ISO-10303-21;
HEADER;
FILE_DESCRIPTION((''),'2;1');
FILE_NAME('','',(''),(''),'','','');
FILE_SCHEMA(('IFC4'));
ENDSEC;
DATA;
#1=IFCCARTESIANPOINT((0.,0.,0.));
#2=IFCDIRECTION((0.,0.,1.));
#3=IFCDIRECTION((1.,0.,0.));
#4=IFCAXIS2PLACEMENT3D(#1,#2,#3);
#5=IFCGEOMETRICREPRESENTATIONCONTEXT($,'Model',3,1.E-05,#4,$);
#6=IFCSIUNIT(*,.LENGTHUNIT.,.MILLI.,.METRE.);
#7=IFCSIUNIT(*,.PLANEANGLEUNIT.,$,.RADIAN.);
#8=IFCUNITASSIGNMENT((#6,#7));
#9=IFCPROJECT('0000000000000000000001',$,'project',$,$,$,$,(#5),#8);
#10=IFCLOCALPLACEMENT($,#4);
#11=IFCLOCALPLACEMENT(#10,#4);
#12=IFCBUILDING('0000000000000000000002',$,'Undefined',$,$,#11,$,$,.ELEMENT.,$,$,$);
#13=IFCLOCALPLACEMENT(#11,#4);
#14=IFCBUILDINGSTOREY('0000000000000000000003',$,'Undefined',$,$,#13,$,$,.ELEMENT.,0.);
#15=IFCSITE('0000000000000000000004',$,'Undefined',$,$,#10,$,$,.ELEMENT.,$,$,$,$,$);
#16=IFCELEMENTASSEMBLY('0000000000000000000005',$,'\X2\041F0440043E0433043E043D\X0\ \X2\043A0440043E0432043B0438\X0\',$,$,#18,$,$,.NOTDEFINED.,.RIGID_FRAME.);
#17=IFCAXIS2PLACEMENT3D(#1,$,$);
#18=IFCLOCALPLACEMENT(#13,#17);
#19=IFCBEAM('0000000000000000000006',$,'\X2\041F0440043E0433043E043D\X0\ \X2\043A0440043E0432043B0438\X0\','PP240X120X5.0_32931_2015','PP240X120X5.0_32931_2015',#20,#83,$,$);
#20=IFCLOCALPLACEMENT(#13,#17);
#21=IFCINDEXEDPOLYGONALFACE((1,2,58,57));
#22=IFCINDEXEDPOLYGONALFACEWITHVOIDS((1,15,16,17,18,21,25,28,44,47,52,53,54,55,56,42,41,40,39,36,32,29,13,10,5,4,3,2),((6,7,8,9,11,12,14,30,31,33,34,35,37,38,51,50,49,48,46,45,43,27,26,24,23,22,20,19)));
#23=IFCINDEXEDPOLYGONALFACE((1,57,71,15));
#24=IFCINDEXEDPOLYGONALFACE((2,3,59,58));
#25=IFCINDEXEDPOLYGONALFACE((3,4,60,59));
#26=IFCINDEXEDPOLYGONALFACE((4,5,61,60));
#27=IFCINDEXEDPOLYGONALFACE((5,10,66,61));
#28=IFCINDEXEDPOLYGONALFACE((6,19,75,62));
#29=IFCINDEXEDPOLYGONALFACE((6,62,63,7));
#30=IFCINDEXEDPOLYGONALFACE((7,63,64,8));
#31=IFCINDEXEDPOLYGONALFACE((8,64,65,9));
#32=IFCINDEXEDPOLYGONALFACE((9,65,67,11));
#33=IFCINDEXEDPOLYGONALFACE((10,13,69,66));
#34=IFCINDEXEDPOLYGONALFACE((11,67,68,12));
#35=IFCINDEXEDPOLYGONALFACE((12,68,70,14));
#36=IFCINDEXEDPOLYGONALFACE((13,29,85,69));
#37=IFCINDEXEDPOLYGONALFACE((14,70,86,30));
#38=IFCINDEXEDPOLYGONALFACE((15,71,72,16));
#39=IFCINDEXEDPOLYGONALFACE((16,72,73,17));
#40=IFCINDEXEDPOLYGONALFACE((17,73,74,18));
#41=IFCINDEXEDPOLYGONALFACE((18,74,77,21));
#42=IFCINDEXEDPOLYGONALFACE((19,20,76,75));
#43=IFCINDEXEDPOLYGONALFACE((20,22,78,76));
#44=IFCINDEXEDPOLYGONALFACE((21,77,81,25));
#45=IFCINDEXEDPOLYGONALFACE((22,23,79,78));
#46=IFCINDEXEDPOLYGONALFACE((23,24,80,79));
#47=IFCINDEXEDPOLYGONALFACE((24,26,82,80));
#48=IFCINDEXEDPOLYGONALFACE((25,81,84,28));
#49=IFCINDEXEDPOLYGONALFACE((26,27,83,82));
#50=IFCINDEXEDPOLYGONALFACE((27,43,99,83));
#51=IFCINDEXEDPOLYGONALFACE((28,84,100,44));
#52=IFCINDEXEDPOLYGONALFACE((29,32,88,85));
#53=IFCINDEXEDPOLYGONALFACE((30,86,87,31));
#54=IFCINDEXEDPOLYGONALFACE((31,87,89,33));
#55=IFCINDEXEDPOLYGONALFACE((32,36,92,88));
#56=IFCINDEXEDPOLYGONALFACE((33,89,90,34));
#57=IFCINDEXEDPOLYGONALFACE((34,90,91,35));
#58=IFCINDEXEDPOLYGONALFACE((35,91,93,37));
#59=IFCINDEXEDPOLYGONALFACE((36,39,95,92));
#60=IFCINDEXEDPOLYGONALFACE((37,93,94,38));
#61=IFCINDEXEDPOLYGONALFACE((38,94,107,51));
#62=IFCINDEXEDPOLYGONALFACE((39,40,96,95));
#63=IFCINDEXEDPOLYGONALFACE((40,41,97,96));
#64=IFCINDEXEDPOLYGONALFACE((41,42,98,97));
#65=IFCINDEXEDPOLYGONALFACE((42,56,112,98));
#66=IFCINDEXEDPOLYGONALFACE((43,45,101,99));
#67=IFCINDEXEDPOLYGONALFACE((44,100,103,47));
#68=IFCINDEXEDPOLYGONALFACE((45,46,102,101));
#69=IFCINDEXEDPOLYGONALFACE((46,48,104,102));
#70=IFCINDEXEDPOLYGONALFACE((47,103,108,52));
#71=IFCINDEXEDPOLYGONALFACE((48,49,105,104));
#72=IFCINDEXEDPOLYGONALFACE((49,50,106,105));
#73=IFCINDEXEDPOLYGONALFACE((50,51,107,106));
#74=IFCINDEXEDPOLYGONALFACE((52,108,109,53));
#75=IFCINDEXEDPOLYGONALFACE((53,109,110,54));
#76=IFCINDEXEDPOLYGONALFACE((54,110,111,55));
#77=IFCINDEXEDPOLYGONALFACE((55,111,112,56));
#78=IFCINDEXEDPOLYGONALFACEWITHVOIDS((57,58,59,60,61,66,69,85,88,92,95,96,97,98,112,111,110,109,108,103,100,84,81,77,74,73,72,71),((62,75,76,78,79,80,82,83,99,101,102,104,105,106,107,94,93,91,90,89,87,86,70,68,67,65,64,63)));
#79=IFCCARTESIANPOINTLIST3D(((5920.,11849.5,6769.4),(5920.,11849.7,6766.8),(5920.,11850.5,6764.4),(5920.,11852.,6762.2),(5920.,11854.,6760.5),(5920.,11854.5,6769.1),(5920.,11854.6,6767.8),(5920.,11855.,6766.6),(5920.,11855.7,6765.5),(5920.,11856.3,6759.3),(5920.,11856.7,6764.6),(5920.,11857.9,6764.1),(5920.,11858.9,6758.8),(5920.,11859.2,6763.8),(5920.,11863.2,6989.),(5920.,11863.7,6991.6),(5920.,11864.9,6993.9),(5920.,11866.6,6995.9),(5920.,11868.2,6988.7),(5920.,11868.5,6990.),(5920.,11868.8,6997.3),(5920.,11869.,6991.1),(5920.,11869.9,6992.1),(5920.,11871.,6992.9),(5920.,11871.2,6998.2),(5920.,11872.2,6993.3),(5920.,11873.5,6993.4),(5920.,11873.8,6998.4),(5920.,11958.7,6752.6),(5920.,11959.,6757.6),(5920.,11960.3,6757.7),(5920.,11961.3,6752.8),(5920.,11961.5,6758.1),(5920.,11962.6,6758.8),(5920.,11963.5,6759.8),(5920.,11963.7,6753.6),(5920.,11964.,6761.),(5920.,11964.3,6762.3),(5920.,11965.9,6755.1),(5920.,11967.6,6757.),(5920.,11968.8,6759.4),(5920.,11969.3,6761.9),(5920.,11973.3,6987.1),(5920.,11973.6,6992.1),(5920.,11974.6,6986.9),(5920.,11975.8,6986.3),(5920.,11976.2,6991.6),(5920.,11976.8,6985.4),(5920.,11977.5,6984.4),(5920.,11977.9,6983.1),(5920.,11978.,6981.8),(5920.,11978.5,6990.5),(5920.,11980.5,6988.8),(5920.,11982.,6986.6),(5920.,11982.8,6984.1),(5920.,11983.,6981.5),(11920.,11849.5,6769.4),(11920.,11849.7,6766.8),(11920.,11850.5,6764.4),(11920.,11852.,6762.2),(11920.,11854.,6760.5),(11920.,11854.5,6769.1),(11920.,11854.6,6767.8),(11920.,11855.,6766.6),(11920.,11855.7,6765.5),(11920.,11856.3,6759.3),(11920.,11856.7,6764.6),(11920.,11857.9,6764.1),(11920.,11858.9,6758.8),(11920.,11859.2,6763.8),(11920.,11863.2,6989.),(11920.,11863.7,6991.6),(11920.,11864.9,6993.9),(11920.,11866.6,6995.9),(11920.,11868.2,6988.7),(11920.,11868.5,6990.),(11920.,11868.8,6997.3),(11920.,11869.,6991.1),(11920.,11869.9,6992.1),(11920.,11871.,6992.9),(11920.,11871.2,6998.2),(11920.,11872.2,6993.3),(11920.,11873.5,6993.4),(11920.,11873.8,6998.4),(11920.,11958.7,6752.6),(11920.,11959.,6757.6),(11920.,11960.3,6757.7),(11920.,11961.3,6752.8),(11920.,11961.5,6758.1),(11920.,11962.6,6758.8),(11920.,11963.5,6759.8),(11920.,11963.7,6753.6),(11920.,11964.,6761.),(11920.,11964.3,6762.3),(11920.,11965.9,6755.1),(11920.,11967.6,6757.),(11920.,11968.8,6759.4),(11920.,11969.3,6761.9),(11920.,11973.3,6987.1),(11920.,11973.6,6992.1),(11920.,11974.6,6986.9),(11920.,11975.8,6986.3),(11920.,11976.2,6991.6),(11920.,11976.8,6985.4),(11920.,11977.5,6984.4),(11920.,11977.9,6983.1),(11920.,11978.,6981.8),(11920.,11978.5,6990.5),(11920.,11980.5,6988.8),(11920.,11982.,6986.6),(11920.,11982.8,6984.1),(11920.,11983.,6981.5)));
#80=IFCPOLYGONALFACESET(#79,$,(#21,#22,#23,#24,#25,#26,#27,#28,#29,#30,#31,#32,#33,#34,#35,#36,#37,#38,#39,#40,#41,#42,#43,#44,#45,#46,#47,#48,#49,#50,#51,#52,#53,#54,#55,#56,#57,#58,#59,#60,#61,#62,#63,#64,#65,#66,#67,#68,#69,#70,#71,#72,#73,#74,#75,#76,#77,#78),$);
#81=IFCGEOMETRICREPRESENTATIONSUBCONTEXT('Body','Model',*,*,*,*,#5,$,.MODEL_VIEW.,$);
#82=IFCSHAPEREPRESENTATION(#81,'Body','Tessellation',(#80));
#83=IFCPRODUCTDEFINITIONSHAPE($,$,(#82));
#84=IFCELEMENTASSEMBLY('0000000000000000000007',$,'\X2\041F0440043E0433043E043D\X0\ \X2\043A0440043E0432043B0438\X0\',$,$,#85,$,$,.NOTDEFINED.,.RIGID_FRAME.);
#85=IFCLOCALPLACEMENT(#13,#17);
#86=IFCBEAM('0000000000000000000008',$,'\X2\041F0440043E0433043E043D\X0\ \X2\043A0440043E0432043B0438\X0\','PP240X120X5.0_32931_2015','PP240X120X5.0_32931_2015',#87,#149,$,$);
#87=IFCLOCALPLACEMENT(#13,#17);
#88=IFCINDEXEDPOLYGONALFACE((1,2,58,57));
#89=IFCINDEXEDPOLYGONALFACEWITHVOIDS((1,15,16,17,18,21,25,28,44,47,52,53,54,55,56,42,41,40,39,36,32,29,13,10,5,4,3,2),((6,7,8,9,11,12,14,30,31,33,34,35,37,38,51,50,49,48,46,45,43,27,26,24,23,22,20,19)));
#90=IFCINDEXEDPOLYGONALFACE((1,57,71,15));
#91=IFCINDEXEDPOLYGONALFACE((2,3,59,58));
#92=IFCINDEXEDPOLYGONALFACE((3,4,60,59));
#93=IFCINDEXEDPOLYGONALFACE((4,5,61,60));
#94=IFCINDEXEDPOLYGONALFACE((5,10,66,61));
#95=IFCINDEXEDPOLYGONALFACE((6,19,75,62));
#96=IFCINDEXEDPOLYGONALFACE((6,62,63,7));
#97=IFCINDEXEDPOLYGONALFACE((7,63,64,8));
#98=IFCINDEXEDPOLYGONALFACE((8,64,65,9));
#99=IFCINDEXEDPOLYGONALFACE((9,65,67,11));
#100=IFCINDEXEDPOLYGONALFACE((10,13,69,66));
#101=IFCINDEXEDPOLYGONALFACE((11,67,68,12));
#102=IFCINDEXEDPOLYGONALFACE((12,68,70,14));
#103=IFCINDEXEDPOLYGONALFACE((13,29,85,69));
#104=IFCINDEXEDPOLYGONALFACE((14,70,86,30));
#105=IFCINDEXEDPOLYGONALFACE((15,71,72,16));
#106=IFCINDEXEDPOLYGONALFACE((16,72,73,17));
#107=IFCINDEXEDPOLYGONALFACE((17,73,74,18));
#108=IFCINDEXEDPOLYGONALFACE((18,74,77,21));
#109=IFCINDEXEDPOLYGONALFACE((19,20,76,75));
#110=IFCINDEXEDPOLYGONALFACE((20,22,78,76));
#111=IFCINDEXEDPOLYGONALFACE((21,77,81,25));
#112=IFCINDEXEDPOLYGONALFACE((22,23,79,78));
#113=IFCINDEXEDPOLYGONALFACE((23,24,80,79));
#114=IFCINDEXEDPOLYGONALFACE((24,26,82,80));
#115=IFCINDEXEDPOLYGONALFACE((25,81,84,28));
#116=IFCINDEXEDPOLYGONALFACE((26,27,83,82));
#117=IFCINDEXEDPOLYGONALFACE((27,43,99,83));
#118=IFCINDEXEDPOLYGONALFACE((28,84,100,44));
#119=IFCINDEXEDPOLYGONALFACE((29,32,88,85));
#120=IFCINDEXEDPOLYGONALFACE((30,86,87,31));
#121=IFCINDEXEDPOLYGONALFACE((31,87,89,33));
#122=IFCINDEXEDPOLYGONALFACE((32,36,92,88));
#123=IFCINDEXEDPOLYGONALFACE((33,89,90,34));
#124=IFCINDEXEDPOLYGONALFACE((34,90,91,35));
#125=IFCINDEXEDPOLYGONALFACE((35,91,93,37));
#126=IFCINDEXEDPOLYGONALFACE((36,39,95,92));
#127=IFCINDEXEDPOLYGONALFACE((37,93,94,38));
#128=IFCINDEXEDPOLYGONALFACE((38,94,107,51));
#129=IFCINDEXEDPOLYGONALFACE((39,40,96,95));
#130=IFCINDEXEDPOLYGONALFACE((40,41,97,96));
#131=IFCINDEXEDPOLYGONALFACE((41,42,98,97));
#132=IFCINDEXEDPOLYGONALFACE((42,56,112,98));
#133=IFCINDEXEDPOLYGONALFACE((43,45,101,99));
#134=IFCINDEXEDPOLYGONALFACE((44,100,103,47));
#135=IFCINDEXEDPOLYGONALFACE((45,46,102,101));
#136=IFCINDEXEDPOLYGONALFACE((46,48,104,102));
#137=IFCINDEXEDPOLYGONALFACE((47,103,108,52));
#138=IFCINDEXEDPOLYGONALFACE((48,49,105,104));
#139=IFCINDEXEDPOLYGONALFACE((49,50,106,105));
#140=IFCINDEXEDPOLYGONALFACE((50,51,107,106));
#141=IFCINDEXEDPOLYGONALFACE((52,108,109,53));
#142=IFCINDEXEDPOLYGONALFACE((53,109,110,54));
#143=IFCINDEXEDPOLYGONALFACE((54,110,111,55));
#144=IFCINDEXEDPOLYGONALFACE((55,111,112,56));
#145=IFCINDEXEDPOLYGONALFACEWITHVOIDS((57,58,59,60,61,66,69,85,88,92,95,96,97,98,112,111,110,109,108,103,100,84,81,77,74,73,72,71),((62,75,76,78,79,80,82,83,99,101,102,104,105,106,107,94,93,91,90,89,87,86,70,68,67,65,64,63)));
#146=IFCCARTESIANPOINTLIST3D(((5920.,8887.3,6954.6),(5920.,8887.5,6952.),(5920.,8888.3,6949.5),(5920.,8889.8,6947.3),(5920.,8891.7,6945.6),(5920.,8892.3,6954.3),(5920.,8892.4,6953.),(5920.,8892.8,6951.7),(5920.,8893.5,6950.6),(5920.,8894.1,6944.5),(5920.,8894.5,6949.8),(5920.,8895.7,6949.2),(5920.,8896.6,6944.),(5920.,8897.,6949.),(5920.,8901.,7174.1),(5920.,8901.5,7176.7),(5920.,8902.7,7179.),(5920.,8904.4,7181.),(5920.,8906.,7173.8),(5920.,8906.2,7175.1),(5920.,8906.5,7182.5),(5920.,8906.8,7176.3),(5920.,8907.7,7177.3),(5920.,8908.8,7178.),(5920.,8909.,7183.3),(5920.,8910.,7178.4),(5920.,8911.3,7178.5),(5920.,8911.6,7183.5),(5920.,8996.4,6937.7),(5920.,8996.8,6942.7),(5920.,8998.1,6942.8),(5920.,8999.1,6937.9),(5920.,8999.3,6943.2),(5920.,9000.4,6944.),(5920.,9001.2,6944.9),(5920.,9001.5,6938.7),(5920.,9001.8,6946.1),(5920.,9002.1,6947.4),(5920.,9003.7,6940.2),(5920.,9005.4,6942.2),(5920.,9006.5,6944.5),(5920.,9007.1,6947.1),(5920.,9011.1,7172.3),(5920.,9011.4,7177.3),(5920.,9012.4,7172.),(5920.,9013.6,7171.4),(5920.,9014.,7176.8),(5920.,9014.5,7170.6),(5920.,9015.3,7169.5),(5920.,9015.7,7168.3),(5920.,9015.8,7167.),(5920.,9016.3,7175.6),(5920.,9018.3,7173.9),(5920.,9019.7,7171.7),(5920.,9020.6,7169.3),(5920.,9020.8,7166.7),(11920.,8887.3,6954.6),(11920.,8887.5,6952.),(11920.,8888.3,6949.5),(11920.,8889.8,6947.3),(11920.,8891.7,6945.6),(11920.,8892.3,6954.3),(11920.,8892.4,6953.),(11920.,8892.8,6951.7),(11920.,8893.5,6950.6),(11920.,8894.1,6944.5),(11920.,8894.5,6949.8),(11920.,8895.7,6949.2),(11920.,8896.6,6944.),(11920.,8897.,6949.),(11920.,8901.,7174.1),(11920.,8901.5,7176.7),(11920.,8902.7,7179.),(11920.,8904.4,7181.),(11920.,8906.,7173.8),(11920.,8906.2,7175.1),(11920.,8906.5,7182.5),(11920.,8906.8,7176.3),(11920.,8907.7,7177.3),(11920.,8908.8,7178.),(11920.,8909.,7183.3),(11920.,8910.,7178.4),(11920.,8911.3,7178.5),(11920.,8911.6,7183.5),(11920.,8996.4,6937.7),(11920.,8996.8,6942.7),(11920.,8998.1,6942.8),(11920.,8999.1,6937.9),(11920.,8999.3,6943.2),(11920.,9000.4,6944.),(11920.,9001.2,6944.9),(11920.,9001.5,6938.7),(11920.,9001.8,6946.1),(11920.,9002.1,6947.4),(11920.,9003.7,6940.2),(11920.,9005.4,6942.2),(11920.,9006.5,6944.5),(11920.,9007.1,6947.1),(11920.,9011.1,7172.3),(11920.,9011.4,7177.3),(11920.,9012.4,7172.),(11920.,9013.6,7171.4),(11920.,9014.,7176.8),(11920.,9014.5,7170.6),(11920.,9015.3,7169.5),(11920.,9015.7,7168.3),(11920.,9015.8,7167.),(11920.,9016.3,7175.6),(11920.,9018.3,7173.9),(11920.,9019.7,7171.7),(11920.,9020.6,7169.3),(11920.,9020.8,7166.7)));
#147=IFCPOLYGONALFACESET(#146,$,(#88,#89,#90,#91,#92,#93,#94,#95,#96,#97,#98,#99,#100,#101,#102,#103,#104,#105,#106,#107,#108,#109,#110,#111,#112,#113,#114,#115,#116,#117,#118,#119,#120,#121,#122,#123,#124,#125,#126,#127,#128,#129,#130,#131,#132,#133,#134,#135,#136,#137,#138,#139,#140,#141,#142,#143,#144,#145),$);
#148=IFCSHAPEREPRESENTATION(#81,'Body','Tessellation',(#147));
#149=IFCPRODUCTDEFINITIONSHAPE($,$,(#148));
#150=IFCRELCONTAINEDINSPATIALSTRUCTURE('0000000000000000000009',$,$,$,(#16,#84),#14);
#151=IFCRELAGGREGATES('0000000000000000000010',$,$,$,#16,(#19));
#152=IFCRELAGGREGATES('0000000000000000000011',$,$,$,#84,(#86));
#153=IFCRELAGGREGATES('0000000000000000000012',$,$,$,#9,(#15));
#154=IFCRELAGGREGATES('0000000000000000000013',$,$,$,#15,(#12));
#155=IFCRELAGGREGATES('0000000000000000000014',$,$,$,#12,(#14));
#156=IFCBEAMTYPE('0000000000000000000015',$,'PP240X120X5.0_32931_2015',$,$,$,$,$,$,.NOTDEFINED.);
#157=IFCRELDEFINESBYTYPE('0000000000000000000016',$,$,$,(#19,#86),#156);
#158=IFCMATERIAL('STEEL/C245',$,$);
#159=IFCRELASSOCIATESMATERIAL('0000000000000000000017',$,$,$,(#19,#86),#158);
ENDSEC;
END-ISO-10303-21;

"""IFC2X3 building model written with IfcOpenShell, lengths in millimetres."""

from ifc_helpers import new_model, si_unit, frame, origin_with_axes, origin_2d_with_axis, place, context, subcontext, project, spatial, hollow_rectangle, extrude, material, type_object, element, aggregate, save


model = new_model("IFC2X3")

# Units and contexts
model_context = context("Model", 3, precision=1e-05, world=origin_with_axes())
body_context = subcontext(model_context, "Body", "Model", "MODEL_VIEW")
ifc_project = project(units=[si_unit("LENGTHUNIT", "METRE", prefix="MILLI"), si_unit("PLANEANGLEUNIT", "RADIAN")], contexts=[model_context])

# Site, building, storey
site_placement = place(None, origin_with_axes())
site = spatial("IfcSite", under=ifc_project, at=site_placement, Name="Undefined", CompositionType="ELEMENT")
building_placement = place(site_placement, origin_with_axes())
building = spatial("IfcBuilding", under=site, at=building_placement, Name="Undefined", CompositionType="ELEMENT")
storey_placement = place(building_placement, origin_with_axes())
storey = spatial("IfcBuildingStorey", under=building, at=storey_placement, Name="Undefined", CompositionType="ELEMENT", Elevation=0.0)

# Shared definitions
ifc_material = material(Name="STEEL/C245")

# Element assemblies, beams
beam_type_1 = type_object("IfcBeamType", Name="PP240X120X5.0_32931_2015", PredefinedType="NOTDEFINED")
assembly_1_placement = place(storey_placement, origin_with_axes())
assembly_1 = element("IfcElementAssembly", 1, at=assembly_1_placement, inside=storey, Name="Прогон кровли", AssemblyPlace="NOTDEFINED", PredefinedType="RIGID_FRAME")
beam_1_placement = place(assembly_1_placement, frame((11920.0, 11916.2, 6875.5), z_axis=(0.0, 0.062378, 0.998053), x_axis=(-1.0, 0.0, 0.0)))
beam_1 = element("IfcBeam", 2, at=beam_1_placement, type_object=beam_type_1, material=ifc_material, Name="Прогон кровли", Description="PP240X120X5.0_32931_2015", ObjectType="PP240X120X5.0_32931_2015", context=body_context, shape_type="SweptSolid", body=[
    extrude(hollow_rectangle(XDim=120.0, YDim=240.0, WallThickness=5.0, InnerFilletRadius=5.0, OuterFilletRadius=10.0, at=origin_2d_with_axis()), frame((6000.0, 0.0, 0.0), z_axis=(-1.0, 0.0, 0.0), x_axis=(0.0, -1.0, 0.0)), (0.0, 0.0, 1.0), 6000.0),
])
aggregate(assembly_1, [beam_1])
assembly_2_placement = place(storey_placement, origin_with_axes())
assembly_2 = element("IfcElementAssembly", 3, at=assembly_2_placement, inside=storey, Name="Прогон кровли", AssemblyPlace="NOTDEFINED", PredefinedType="RIGID_FRAME")
beam_2_placement = place(assembly_2_placement, frame((11920.0, 8954.0, 7060.6), z_axis=(0.0, 0.062378, 0.998053), x_axis=(-1.0, 0.0, 0.0)))
beam_2 = element("IfcBeam", 4, at=beam_2_placement, type_object=beam_type_1, material=ifc_material, Name="Прогон кровли", Description="PP240X120X5.0_32931_2015", ObjectType="PP240X120X5.0_32931_2015", context=body_context, shape_type="SweptSolid", body=[
    extrude(hollow_rectangle(XDim=120.0, YDim=240.0, WallThickness=5.0, InnerFilletRadius=5.0, OuterFilletRadius=10.0, at=origin_2d_with_axis()), frame((6000.0, 0.0, 0.0), z_axis=(-1.0, 0.0, 0.0), x_axis=(0.0, -1.0, 0.0)), (0.0, 0.0, 1.0), 6000.0),
])
aggregate(assembly_2, [beam_2])

save(model, "model.ifc")
